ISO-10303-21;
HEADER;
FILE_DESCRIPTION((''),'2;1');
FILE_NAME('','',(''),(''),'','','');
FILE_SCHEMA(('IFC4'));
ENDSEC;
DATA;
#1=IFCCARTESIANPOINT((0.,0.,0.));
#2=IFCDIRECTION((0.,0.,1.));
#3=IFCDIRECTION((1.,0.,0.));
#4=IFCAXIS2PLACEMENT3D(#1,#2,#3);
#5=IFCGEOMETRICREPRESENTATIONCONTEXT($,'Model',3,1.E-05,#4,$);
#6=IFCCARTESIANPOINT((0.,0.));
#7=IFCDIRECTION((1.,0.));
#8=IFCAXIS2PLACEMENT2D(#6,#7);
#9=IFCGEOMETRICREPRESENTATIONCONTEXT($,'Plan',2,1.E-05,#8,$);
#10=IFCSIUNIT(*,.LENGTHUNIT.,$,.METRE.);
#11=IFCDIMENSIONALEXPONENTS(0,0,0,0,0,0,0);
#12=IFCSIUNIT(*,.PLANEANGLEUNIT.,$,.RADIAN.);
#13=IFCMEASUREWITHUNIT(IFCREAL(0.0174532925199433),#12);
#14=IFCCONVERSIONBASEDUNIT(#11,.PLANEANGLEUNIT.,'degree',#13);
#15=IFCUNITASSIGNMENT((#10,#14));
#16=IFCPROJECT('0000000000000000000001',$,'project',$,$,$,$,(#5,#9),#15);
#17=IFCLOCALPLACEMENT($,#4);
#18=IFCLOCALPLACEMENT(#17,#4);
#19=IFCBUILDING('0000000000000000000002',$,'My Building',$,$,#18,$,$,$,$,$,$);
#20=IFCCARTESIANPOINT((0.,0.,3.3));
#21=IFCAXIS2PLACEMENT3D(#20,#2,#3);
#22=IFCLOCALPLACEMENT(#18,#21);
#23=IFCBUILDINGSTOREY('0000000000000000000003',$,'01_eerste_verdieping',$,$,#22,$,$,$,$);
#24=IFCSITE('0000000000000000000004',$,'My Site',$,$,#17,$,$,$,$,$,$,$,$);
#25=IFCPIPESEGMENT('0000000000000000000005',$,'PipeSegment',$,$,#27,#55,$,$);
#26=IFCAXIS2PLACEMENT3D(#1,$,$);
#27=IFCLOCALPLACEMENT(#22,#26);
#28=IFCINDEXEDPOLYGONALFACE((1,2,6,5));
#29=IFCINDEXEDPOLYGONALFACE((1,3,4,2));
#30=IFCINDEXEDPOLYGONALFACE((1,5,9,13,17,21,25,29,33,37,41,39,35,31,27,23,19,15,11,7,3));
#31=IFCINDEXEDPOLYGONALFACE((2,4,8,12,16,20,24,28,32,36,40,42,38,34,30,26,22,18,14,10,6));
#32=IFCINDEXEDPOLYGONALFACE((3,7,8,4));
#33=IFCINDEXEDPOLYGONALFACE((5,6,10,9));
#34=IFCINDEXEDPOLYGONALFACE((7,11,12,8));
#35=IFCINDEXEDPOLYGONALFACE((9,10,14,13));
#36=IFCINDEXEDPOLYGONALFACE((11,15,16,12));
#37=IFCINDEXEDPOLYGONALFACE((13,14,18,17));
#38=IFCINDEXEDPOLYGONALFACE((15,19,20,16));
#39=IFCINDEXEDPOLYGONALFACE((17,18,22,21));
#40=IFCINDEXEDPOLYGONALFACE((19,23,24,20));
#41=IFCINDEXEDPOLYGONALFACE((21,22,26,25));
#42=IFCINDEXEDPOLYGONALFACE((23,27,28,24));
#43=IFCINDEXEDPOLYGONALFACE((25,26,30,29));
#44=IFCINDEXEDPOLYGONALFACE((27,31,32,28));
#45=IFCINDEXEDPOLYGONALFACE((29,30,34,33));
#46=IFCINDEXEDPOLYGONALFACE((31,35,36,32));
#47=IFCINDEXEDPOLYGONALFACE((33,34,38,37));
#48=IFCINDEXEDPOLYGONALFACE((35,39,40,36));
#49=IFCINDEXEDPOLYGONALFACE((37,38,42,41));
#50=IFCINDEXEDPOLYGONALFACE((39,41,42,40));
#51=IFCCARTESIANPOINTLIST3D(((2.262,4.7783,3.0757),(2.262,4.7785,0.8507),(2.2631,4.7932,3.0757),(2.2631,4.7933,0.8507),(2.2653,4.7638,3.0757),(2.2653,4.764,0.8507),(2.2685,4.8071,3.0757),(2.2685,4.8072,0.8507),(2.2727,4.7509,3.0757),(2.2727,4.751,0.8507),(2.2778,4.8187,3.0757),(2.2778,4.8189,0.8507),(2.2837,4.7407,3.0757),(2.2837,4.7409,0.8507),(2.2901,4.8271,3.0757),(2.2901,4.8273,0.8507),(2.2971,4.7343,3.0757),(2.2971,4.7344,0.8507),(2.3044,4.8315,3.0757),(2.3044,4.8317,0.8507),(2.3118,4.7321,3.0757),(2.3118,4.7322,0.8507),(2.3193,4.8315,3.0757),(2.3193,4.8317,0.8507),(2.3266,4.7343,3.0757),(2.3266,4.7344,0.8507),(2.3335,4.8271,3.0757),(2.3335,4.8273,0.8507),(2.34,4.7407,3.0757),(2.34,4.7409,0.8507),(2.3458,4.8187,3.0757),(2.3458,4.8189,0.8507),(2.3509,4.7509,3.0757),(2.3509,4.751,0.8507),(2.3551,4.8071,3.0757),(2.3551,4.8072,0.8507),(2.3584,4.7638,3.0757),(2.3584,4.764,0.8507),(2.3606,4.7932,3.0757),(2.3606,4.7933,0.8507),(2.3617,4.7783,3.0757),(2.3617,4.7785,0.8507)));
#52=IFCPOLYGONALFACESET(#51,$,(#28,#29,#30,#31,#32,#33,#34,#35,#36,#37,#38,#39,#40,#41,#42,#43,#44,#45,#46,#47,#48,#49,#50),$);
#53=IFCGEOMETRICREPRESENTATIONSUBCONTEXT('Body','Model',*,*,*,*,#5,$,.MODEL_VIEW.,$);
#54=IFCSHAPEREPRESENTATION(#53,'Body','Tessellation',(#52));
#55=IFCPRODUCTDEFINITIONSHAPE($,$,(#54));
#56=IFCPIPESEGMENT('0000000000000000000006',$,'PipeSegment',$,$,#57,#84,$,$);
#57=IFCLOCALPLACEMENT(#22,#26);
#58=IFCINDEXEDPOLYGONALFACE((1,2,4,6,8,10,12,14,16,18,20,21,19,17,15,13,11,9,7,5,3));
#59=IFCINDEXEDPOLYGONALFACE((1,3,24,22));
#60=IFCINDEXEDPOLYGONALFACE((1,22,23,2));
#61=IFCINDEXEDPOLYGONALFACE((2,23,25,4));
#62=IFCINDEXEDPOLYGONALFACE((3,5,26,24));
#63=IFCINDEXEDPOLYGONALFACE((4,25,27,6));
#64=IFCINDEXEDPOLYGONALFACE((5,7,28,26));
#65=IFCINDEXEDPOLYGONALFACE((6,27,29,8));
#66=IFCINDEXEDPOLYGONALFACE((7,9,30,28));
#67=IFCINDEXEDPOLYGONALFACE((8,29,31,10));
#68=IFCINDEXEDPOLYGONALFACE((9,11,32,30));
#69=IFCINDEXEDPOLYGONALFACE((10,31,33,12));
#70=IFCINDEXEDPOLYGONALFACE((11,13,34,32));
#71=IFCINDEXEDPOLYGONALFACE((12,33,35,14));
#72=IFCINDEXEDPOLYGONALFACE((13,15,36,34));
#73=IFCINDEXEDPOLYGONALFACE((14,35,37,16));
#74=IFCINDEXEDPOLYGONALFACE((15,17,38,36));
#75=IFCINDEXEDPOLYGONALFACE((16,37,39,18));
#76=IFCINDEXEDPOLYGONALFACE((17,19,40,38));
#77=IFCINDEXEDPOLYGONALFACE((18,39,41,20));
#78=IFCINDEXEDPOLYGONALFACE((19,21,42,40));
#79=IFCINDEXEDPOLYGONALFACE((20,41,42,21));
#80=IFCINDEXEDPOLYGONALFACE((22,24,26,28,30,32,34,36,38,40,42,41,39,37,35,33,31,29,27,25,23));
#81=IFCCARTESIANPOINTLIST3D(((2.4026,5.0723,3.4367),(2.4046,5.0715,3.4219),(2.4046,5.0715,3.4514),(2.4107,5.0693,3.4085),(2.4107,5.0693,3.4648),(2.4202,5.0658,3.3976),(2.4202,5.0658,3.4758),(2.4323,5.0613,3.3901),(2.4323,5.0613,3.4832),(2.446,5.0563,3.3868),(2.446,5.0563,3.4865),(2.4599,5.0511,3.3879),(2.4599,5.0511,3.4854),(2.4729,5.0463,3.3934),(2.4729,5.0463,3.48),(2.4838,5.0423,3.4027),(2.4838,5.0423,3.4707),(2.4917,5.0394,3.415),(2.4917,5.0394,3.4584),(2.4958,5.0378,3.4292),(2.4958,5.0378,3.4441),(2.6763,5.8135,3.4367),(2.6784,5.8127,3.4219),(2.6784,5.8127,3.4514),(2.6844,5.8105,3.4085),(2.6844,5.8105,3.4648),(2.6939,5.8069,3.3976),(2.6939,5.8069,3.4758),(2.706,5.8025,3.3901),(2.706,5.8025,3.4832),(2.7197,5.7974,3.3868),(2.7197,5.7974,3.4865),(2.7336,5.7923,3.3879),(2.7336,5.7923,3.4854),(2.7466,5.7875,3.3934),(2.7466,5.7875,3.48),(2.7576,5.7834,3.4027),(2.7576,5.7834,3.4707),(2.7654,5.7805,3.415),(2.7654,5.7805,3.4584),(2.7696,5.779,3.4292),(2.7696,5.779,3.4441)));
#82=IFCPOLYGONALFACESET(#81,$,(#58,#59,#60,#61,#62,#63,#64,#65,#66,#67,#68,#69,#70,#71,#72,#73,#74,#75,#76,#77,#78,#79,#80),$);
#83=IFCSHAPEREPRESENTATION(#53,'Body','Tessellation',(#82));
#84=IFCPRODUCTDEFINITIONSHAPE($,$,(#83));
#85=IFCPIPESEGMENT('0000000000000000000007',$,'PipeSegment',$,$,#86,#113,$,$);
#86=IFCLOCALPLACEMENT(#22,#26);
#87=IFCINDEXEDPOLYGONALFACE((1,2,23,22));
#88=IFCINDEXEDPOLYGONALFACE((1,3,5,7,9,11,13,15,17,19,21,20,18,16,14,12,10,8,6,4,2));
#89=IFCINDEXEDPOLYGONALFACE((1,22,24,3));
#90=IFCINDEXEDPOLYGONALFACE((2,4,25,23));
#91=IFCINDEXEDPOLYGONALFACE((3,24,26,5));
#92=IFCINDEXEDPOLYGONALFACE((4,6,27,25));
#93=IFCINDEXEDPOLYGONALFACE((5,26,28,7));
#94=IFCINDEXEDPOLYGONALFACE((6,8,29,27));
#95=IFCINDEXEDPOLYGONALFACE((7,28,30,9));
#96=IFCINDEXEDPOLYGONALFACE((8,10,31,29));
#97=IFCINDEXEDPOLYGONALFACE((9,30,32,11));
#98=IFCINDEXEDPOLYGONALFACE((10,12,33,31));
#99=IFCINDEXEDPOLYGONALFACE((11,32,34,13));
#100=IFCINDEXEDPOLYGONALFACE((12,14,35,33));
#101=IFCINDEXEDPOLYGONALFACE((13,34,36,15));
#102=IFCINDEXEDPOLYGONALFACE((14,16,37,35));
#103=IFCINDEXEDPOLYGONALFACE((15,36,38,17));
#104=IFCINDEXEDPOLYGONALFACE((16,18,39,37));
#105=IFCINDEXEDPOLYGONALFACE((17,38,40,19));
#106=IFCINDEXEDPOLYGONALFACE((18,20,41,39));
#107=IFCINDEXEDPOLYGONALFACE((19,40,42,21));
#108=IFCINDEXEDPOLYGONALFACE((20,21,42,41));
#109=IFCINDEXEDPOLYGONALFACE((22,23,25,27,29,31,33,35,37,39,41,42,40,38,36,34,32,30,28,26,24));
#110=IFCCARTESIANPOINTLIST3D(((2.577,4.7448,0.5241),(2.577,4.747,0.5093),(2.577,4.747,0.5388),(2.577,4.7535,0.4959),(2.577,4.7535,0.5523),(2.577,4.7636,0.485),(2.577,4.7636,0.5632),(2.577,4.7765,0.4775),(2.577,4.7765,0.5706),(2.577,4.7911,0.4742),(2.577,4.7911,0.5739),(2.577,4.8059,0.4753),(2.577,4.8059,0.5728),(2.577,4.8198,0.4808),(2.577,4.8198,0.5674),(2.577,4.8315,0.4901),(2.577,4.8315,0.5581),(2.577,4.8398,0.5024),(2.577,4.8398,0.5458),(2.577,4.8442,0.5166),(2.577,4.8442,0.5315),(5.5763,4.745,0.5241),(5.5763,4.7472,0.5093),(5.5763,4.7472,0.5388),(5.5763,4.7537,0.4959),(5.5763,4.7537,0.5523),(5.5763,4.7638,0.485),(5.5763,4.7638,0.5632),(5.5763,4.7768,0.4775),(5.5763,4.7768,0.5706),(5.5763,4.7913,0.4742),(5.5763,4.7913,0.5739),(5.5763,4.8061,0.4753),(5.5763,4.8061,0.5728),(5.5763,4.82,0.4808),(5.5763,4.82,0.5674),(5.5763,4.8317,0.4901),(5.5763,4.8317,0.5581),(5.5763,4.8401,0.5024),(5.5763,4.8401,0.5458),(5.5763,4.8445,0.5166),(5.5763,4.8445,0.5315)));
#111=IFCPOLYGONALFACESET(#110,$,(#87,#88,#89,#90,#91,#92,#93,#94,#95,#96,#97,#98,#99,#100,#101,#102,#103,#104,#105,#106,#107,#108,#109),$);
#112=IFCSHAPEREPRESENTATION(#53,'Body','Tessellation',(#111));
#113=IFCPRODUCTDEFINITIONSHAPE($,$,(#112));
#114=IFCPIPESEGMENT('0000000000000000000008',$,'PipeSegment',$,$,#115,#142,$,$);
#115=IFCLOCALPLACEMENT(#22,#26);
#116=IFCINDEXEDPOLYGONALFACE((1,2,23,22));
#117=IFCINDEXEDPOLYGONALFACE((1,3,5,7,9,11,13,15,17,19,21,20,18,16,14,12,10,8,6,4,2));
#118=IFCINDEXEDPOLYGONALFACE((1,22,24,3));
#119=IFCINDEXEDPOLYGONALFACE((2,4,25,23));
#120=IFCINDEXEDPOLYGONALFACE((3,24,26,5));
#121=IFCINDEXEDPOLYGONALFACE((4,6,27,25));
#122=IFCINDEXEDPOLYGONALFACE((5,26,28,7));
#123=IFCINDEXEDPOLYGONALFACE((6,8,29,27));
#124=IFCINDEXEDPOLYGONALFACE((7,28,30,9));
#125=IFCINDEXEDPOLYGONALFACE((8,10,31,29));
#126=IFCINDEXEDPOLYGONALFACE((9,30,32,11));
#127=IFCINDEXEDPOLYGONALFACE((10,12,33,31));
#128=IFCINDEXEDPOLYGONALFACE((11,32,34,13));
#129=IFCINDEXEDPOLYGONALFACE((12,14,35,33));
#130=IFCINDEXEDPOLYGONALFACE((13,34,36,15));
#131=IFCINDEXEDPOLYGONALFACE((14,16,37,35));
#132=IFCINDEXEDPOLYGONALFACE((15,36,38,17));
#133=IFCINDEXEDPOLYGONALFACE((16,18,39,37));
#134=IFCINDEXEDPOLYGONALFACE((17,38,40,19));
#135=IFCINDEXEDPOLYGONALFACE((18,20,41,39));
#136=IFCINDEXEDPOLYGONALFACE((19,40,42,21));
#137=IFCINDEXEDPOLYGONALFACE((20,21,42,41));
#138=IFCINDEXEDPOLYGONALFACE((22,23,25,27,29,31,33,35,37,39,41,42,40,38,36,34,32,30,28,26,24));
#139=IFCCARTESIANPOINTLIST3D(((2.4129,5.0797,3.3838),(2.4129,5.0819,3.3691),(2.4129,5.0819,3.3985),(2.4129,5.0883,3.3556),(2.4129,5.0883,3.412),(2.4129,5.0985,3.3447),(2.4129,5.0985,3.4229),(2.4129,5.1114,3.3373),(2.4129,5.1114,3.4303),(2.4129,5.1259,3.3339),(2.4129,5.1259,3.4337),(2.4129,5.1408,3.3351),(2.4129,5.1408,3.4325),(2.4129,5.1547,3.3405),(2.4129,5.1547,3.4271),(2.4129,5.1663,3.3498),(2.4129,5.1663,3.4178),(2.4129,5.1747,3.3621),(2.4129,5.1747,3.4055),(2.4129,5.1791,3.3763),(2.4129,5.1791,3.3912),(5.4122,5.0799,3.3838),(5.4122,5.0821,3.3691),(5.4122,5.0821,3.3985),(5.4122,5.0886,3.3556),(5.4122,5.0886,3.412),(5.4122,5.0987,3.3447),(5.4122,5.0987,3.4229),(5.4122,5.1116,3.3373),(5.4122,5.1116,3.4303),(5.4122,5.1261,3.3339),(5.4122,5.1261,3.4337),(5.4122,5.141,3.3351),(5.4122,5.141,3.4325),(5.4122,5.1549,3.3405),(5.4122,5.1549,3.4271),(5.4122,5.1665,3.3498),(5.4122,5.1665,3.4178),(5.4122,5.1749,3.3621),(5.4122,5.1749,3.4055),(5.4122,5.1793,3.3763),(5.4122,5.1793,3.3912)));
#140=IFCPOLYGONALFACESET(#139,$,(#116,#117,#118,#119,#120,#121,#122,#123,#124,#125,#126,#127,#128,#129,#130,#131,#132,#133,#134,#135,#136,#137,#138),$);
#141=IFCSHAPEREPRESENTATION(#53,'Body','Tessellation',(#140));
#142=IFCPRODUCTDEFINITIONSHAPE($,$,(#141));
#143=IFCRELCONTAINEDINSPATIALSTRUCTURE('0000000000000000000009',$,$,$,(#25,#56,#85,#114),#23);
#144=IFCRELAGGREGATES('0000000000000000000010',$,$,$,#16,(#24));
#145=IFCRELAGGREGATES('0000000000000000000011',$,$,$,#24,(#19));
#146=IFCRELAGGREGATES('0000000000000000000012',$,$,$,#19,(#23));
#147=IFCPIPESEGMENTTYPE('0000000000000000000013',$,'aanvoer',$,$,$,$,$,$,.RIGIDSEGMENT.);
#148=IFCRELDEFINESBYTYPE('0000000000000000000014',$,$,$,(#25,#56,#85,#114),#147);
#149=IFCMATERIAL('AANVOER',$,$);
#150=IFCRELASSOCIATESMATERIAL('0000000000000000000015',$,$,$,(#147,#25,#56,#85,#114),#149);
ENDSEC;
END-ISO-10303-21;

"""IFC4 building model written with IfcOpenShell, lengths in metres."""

from ifc_helpers import new_model, entity, si_unit, converted_unit, frame, origin_with_axes, origin_2d_with_axis, place, context, subcontext, project, spatial, circle, extrude, material, material_profile, profile_set, profile_usage, type_object, element, save


model = new_model("IFC4")

# Units and contexts
model_context = context("Model", 3, precision=1e-05, world=origin_with_axes())
plan_context = context("Plan", 2, precision=1e-05, world=origin_2d_with_axis())
body_context_1 = subcontext(model_context, "Body", "Model", "MODEL_VIEW")
ifc_project = project(units=[si_unit("LENGTHUNIT", "METRE"), converted_unit("PLANEANGLEUNIT", "degree", entity("IfcReal", 0.0174532925199433), si_unit("PLANEANGLEUNIT", "RADIAN"), dimensions=[0, 0, 0, 0, 0, 0, 0])], contexts=[model_context, plan_context])

# Site, building, storey
site_placement = place(None, origin_with_axes())
site = spatial("IfcSite", under=ifc_project, at=site_placement, Name="My Site")
building_placement = place(site_placement, origin_with_axes())
building = spatial("IfcBuilding", under=site, at=building_placement, Name="My Building")
storey_placement = place(building_placement, frame((0.0, 0.0, 3.3), z_axis=(0.0, 0.0, 1.0), x_axis=(1.0, 0.0, 0.0)))
storey = spatial("IfcBuildingStorey", under=building, at=storey_placement, Name="01_eerste_verdieping")

# Pipe segments
ifc_material_1 = material(Name="AANVOER")
ifc_material_profile_1 = material_profile(ifc_material_1, circle(Radius=0.05))
ifc_profile_set_1 = profile_set([ifc_material_profile_1])
pipe_segment_type_1 = type_object("IfcPipeSegmentType", Name="aanvoer", PredefinedType="RIGIDSEGMENT", material=ifc_profile_set_1)
ifc_profile_usage_1 = profile_usage(ifc_profile_set_1)
pipe_segment_1_placement = place(storey_placement, frame((2.3118, 4.7822, 0.8507), z_axis=(0.0, -0.000073, 1.0), x_axis=(0.0, -1.0, -0.000073)))
element("IfcPipeSegment", 1, at=pipe_segment_1_placement, inside=storey, type_object=pipe_segment_type_1, material=ifc_profile_usage_1, Name="PipeSegment", context=body_context_1, shape_type="SweptSolid", body=[
    extrude(circle(Radius=0.05), origin_with_axes(), (0.0, 0.0, 1.0), 2.225),
])
ifc_profile_usage_2 = profile_usage(ifc_profile_set_1)
pipe_segment_2_placement = place(storey_placement, frame((2.4495, 5.055, 3.4367), z_axis=(0.34643, 0.938076, 0.0), x_axis=(-0.938076, 0.34643, 0.0)))
element("IfcPipeSegment", 2, at=pipe_segment_2_placement, inside=storey, type_object=pipe_segment_type_1, material=ifc_profile_usage_2, Name="PipeSegment", context=body_context_1, shape_type="SweptSolid", body=[
    extrude(circle(Radius=0.05), origin_with_axes(), (0.0, 0.0, 1.0), 0.7901),
])
ifc_profile_usage_3 = profile_usage(ifc_profile_set_1)
pipe_segment_3_placement = place(storey_placement, frame((5.5763, 4.795, 0.5241), z_axis=(-1.0, -0.000073, 0.0), x_axis=(0.000073, -1.0, 0.0)))
element("IfcPipeSegment", 3, at=pipe_segment_3_placement, inside=storey, type_object=pipe_segment_type_1, material=ifc_profile_usage_3, Name="PipeSegment", context=body_context_1, shape_type="SweptSolid", body=[
    extrude(circle(Radius=0.05), origin_with_axes(), (0.0, 0.0, 1.0), 2.9994),
])
ifc_profile_usage_4 = profile_usage(ifc_profile_set_1)
pipe_segment_4_placement = place(storey_placement, frame((5.4122, 5.1299, 3.3838), z_axis=(-1.0, -0.000073, 0.0), x_axis=(0.000073, -1.0, 0.0)))
element("IfcPipeSegment", 4, at=pipe_segment_4_placement, inside=storey, type_object=pipe_segment_type_1, material=ifc_profile_usage_4, Name="PipeSegment", context=body_context_1, shape_type="SweptSolid", body=[
    extrude(circle(Radius=0.05), origin_with_axes(), (0.0, 0.0, 1.0), 2.9994),
])

save(model, "model.ifc")
